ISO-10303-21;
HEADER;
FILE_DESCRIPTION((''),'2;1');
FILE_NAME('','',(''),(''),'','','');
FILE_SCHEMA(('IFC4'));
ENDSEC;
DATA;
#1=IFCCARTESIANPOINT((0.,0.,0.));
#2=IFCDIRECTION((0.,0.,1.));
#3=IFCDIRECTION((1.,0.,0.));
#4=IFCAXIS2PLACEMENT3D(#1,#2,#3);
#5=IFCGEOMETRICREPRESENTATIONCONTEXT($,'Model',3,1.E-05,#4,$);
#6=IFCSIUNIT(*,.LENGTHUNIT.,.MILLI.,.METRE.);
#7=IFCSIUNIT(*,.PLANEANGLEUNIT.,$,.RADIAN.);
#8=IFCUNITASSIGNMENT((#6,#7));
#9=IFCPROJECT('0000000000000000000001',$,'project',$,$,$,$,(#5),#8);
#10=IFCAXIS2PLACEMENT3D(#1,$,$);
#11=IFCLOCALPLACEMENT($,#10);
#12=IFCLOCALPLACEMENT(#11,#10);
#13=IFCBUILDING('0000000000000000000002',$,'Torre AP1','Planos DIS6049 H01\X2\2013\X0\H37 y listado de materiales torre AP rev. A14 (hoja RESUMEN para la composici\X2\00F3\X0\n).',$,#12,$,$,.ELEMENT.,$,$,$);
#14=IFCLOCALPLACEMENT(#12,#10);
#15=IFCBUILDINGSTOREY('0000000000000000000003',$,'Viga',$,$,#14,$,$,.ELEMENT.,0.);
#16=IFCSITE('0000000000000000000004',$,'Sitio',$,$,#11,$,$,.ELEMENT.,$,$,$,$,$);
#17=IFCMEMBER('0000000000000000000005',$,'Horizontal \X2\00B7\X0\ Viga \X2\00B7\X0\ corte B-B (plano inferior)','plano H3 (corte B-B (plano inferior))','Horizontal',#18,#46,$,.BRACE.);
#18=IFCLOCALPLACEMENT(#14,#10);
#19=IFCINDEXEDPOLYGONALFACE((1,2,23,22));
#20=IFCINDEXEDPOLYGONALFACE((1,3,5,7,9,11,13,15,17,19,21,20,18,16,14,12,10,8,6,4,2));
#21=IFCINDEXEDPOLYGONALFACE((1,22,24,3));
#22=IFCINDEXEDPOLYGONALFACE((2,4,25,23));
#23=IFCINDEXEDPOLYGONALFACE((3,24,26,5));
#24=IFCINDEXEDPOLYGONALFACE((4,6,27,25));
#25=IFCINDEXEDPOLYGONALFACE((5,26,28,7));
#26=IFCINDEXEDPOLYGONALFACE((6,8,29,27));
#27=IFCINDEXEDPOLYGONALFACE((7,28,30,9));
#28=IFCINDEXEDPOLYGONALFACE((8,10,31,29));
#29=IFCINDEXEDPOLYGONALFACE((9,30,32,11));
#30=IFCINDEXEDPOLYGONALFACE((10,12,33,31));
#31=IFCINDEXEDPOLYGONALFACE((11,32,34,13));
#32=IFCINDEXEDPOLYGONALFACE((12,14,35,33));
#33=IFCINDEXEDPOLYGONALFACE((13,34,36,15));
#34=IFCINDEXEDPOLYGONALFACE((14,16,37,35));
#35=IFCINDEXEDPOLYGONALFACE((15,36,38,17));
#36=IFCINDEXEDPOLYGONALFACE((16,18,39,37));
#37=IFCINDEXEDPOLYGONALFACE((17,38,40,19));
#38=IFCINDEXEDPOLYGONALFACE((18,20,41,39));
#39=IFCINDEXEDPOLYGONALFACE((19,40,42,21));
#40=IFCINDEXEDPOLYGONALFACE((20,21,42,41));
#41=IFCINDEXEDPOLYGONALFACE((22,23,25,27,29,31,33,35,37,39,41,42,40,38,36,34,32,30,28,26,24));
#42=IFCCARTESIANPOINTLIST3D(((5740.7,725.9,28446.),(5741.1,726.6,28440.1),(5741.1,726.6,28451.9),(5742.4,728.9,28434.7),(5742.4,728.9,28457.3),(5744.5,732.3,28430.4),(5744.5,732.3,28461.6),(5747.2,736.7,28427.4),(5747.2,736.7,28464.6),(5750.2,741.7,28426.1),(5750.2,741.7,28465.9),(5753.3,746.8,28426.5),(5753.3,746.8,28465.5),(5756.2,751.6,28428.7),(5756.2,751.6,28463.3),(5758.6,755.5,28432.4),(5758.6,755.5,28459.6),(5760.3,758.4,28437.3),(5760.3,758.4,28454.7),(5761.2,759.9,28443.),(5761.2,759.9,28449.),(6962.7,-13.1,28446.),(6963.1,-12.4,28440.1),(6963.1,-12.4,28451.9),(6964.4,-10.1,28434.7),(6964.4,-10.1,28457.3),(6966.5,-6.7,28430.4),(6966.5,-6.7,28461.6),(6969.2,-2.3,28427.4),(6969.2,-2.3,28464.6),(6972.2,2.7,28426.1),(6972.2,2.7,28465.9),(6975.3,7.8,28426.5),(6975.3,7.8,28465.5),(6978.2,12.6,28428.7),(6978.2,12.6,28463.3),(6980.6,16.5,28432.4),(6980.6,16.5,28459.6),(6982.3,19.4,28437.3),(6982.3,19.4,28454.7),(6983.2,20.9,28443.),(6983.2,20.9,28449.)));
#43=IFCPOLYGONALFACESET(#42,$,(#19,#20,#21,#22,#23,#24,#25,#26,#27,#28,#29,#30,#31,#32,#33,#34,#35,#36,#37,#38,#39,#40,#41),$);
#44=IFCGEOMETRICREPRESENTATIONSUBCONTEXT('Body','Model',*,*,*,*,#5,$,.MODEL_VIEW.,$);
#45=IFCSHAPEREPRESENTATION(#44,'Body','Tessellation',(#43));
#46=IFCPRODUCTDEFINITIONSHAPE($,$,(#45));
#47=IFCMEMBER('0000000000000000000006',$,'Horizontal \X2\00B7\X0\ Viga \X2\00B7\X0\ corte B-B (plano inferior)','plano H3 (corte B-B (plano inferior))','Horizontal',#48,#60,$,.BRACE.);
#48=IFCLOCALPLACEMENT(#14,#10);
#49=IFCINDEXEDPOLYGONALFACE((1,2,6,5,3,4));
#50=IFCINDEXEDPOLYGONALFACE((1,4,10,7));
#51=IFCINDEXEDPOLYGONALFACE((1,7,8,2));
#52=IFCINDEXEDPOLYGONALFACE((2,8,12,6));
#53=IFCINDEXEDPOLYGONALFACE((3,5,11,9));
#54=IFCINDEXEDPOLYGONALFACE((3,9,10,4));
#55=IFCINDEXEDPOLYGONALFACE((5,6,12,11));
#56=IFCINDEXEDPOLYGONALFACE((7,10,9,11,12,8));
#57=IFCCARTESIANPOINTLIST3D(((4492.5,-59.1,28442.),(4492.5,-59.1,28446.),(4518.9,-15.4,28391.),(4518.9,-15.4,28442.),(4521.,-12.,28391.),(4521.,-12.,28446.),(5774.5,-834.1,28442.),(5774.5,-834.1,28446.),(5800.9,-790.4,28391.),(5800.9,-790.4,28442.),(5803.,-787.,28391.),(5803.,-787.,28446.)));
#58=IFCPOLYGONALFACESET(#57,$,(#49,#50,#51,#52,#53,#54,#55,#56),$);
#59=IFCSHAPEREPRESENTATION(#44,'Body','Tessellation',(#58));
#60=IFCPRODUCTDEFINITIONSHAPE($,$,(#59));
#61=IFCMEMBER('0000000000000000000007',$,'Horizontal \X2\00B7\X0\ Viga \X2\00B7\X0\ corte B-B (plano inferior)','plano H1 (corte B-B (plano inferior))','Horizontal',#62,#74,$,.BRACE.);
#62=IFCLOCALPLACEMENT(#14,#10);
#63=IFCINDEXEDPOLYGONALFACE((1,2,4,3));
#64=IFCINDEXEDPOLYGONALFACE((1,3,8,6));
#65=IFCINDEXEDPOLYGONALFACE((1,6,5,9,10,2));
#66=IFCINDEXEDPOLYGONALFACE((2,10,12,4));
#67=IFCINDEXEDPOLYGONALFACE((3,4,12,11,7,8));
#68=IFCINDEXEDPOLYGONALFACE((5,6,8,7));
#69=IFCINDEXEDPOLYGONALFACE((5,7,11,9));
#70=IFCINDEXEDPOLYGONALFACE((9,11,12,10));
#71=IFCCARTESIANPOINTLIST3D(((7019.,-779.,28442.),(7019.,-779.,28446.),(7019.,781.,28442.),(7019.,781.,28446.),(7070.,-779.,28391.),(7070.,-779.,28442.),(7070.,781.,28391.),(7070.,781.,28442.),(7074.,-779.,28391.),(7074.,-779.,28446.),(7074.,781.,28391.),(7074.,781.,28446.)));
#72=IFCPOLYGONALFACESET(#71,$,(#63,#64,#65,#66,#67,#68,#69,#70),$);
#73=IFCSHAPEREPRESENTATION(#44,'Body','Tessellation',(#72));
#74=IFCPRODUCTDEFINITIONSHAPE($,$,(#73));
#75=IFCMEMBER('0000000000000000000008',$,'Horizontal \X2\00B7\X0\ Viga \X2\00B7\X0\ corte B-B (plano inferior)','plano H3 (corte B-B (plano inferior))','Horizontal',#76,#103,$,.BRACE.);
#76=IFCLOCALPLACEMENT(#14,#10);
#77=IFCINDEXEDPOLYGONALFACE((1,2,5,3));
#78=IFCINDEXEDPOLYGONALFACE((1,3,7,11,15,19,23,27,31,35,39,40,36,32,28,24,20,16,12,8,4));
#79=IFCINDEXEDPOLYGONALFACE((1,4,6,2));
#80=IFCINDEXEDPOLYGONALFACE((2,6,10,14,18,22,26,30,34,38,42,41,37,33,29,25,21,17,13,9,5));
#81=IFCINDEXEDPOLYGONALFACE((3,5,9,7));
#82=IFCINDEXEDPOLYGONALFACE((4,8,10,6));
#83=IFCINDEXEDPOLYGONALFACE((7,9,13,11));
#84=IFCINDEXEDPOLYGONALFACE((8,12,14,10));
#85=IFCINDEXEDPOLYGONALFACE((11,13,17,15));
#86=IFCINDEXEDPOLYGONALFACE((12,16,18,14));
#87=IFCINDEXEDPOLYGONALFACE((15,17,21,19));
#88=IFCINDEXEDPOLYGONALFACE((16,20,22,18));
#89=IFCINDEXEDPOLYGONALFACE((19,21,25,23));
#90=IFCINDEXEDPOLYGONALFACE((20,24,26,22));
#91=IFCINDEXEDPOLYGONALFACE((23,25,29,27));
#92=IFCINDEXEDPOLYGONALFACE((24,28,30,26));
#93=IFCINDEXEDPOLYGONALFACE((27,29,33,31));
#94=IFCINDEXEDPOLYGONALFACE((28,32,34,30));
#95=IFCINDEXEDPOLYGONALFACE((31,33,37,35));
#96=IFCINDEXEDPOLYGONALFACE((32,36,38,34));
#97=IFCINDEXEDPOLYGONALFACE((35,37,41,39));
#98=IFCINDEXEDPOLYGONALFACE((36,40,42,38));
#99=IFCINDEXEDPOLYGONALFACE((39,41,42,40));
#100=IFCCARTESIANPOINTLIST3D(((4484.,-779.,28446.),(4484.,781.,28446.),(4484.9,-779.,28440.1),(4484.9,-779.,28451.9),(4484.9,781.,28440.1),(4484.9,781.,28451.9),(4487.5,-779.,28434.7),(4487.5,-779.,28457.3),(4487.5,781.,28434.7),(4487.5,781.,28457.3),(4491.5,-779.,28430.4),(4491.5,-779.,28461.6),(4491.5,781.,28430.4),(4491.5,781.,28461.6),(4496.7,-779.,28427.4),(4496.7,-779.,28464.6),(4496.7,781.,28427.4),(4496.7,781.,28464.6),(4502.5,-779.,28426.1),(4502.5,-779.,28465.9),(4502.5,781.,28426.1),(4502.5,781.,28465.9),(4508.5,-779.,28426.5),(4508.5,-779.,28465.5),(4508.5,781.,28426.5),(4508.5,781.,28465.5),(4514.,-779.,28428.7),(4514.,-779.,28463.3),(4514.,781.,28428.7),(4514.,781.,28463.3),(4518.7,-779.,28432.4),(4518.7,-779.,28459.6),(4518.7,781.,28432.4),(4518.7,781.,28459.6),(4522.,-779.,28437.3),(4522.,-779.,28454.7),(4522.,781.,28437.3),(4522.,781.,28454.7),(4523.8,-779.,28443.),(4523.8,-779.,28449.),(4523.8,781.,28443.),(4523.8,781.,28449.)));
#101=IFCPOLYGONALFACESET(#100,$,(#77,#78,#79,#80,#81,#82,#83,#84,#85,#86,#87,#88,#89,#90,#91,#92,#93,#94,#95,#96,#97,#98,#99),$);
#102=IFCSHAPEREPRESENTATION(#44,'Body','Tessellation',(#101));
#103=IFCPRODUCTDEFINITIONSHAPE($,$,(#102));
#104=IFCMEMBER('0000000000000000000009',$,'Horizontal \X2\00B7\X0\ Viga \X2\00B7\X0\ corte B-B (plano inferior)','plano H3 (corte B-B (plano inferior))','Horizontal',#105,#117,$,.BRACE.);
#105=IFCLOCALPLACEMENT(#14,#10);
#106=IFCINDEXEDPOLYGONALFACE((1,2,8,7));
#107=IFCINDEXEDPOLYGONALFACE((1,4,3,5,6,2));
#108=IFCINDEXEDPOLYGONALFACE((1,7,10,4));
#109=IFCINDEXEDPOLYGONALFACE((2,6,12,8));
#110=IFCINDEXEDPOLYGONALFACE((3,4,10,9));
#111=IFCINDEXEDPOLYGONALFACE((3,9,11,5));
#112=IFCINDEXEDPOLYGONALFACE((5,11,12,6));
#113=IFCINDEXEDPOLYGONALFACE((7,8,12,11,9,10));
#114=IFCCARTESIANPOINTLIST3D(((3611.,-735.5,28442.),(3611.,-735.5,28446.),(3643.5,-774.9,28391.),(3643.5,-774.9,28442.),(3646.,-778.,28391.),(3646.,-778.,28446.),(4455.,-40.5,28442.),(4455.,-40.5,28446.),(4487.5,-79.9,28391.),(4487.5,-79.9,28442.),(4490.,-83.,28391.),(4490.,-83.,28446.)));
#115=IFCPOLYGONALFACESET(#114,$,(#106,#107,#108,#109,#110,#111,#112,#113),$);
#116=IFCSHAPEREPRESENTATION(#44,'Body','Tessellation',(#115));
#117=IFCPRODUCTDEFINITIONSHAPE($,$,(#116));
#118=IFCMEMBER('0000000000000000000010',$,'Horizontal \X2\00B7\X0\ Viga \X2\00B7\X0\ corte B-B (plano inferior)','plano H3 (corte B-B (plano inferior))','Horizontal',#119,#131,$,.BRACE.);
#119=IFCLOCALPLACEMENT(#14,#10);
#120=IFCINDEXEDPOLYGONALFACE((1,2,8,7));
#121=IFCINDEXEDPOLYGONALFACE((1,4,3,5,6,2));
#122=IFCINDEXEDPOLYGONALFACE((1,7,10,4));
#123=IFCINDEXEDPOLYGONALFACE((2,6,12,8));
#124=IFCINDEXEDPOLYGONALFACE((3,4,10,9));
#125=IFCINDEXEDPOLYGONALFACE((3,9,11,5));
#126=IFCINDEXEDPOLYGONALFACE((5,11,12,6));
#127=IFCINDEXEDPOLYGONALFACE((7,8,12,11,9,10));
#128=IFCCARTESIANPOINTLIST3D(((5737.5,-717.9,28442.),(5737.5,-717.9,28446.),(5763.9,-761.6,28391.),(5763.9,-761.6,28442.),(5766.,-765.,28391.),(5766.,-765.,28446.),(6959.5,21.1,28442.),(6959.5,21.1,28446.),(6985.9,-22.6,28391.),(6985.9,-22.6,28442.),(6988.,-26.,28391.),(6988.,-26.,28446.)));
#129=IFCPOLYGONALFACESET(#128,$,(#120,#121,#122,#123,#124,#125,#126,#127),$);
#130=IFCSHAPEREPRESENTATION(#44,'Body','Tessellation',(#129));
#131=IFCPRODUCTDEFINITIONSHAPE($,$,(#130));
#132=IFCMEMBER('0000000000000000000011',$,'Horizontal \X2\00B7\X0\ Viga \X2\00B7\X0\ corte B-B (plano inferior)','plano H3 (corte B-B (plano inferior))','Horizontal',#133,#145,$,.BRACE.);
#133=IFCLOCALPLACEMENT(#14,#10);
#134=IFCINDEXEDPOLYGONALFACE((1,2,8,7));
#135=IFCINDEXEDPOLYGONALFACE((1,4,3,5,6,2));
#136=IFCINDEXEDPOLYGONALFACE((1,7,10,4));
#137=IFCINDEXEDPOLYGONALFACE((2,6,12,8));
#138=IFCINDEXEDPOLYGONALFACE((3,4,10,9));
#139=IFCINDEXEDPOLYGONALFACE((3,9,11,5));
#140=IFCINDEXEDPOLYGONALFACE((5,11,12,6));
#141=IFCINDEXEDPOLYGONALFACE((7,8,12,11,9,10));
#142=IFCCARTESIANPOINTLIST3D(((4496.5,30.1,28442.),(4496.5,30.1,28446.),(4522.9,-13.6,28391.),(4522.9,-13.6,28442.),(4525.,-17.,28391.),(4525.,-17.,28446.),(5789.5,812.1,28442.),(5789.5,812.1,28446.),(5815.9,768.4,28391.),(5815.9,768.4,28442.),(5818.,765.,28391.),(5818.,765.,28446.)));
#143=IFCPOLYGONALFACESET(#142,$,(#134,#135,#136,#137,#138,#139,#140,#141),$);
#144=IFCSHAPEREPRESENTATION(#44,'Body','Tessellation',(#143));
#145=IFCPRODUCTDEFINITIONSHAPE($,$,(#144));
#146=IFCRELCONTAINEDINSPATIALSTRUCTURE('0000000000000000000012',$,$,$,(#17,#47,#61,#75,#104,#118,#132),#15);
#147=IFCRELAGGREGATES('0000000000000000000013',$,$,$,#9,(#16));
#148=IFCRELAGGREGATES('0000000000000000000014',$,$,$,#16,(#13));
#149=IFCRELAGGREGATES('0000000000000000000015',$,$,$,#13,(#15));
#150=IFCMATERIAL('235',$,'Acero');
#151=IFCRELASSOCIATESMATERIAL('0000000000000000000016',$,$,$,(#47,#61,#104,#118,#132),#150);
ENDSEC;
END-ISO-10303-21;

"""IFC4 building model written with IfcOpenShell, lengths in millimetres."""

from ifc_helpers import new_model, si_unit, frame, frame_2d, origin, origin_with_axes, place, context, subcontext, project, spatial, circle, l_section, extrude, material, element, save


model = new_model("IFC4")

# Units and contexts
model_context = context("Model", 3, precision=1e-05, world=origin_with_axes())
body_context = subcontext(model_context, "Body", "Model", "MODEL_VIEW")
ifc_project = project(units=[si_unit("LENGTHUNIT", "METRE", prefix="MILLI"), si_unit("PLANEANGLEUNIT", "RADIAN")], contexts=[model_context])

# Site, building, storey
site_placement = place(None, origin())
site = spatial("IfcSite", under=ifc_project, at=site_placement, Name="Sitio", CompositionType="ELEMENT")
building_placement = place(site_placement, origin())
building = spatial("IfcBuilding", under=site, at=building_placement, Name="Torre AP1", Description="Planos DIS6049 H01–H37 y listado de materiales torre AP rev. A14 (hoja RESUMEN para la composición).", CompositionType="ELEMENT")
storey_placement = place(building_placement, origin())
storey = spatial("IfcBuildingStorey", under=building, at=storey_placement, Name="Viga", CompositionType="ELEMENT", Elevation=0.0)

# Members
ifc_material_1 = material(Name="235", Category="Acero")
member_1_placement = place(storey_placement, frame((5751.0, 743.0, 28446.0), z_axis=(0.855696, -0.517479, 0.0), x_axis=(-0.517479, -0.855696, 0.0)))
element("IfcMember", 1, at=member_1_placement, inside=storey, Name="Horizontal · Viga · corte B-B (plano inferior)", Description="plano H3 (corte B-B (plano inferior))", ObjectType="Horizontal", PredefinedType="BRACE", context=body_context, shape_type="SweptSolid", body=[
    extrude(circle(Radius=20.0), None, (0.0, 0.0, 1.0), 1428.1),
])
member_2_placement = place(storey_placement, frame((4521.0, -12.0, 28446.0), z_axis=(0.85578, -0.51734, 0.0), x_axis=(-0.51734, -0.85578, 0.0)))
element("IfcMember", 2, at=member_2_placement, inside=storey, material=ifc_material_1, Name="Horizontal · Viga · corte B-B (plano inferior)", Description="plano H3 (corte B-B (plano inferior))", ObjectType="Horizontal", PredefinedType="BRACE", context=body_context, shape_type="SweptSolid", body=[
    extrude(l_section(Depth=55.0, Width=55.0, Thickness=4.0, at=frame_2d((27.5, 27.5))), None, (0.0, 0.0, 1.0), 1498.0),
])
member_3_placement = place(storey_placement, frame((7074.0, 781.0, 28446.0), z_axis=(0.0, -1.0, 0.0), x_axis=(-1.0, 0.0, 0.0)))
element("IfcMember", 3, at=member_3_placement, inside=storey, material=ifc_material_1, Name="Horizontal · Viga · corte B-B (plano inferior)", Description="plano H1 (corte B-B (plano inferior))", ObjectType="Horizontal", PredefinedType="BRACE", context=body_context, shape_type="SweptSolid", body=[
    extrude(l_section(Depth=55.0, Width=55.0, Thickness=4.0, at=frame_2d((27.5, 27.5))), None, (0.0, 0.0, 1.0), 1560.0),
])
member_4_placement = place(storey_placement, frame((4504.0, 781.0, 28446.0), z_axis=(0.0, -1.0, 0.0), x_axis=(-1.0, 0.0, 0.0)))
element("IfcMember", 4, at=member_4_placement, inside=storey, Name="Horizontal · Viga · corte B-B (plano inferior)", Description="plano H3 (corte B-B (plano inferior))", ObjectType="Horizontal", PredefinedType="BRACE", context=body_context, shape_type="SweptSolid", body=[
    extrude(circle(Radius=20.0), None, (0.0, 0.0, 1.0), 1560.0),
])
member_5_placement = place(storey_placement, frame((4490.0, -83.0, 28446.0), z_axis=(-0.771957, -0.635675, 0.0), x_axis=(-0.635675, 0.771957, 0.0)))
element("IfcMember", 5, at=member_5_placement, inside=storey, material=ifc_material_1, Name="Horizontal · Viga · corte B-B (plano inferior)", Description="plano H3 (corte B-B (plano inferior))", ObjectType="Horizontal", PredefinedType="BRACE", context=body_context, shape_type="SweptSolid", body=[
    extrude(l_section(Depth=55.0, Width=55.0, Thickness=4.0, at=frame_2d((27.5, 27.5))), None, (0.0, 0.0, 1.0), 1093.3),
])
member_6_placement = place(storey_placement, frame((6988.0, -26.0, 28446.0), z_axis=(-0.855696, -0.517479, 0.0), x_axis=(-0.517479, 0.855696, 0.0)))
element("IfcMember", 6, at=member_6_placement, inside=storey, material=ifc_material_1, Name="Horizontal · Viga · corte B-B (plano inferior)", Description="plano H3 (corte B-B (plano inferior))", ObjectType="Horizontal", PredefinedType="BRACE", context=body_context, shape_type="SweptSolid", body=[
    extrude(l_section(Depth=55.0, Width=55.0, Thickness=4.0, at=frame_2d((27.5, 27.5))), None, (0.0, 0.0, 1.0), 1428.1),
])
member_7_placement = place(storey_placement, frame((5818.0, 765.0, 28446.0), z_axis=(-0.855677, -0.517509, 0.0), x_axis=(-0.517509, 0.855677, 0.0)))
element("IfcMember", 7, at=member_7_placement, inside=storey, material=ifc_material_1, Name="Horizontal · Viga · corte B-B (plano inferior)", Description="plano H3 (corte B-B (plano inferior))", ObjectType="Horizontal", PredefinedType="BRACE", context=body_context, shape_type="SweptSolid", body=[
    extrude(l_section(Depth=55.0, Width=55.0, Thickness=4.0, at=frame_2d((27.5, 27.5))), None, (0.0, 0.0, 1.0), 1511.1),
])

save(model, "model.ifc")
